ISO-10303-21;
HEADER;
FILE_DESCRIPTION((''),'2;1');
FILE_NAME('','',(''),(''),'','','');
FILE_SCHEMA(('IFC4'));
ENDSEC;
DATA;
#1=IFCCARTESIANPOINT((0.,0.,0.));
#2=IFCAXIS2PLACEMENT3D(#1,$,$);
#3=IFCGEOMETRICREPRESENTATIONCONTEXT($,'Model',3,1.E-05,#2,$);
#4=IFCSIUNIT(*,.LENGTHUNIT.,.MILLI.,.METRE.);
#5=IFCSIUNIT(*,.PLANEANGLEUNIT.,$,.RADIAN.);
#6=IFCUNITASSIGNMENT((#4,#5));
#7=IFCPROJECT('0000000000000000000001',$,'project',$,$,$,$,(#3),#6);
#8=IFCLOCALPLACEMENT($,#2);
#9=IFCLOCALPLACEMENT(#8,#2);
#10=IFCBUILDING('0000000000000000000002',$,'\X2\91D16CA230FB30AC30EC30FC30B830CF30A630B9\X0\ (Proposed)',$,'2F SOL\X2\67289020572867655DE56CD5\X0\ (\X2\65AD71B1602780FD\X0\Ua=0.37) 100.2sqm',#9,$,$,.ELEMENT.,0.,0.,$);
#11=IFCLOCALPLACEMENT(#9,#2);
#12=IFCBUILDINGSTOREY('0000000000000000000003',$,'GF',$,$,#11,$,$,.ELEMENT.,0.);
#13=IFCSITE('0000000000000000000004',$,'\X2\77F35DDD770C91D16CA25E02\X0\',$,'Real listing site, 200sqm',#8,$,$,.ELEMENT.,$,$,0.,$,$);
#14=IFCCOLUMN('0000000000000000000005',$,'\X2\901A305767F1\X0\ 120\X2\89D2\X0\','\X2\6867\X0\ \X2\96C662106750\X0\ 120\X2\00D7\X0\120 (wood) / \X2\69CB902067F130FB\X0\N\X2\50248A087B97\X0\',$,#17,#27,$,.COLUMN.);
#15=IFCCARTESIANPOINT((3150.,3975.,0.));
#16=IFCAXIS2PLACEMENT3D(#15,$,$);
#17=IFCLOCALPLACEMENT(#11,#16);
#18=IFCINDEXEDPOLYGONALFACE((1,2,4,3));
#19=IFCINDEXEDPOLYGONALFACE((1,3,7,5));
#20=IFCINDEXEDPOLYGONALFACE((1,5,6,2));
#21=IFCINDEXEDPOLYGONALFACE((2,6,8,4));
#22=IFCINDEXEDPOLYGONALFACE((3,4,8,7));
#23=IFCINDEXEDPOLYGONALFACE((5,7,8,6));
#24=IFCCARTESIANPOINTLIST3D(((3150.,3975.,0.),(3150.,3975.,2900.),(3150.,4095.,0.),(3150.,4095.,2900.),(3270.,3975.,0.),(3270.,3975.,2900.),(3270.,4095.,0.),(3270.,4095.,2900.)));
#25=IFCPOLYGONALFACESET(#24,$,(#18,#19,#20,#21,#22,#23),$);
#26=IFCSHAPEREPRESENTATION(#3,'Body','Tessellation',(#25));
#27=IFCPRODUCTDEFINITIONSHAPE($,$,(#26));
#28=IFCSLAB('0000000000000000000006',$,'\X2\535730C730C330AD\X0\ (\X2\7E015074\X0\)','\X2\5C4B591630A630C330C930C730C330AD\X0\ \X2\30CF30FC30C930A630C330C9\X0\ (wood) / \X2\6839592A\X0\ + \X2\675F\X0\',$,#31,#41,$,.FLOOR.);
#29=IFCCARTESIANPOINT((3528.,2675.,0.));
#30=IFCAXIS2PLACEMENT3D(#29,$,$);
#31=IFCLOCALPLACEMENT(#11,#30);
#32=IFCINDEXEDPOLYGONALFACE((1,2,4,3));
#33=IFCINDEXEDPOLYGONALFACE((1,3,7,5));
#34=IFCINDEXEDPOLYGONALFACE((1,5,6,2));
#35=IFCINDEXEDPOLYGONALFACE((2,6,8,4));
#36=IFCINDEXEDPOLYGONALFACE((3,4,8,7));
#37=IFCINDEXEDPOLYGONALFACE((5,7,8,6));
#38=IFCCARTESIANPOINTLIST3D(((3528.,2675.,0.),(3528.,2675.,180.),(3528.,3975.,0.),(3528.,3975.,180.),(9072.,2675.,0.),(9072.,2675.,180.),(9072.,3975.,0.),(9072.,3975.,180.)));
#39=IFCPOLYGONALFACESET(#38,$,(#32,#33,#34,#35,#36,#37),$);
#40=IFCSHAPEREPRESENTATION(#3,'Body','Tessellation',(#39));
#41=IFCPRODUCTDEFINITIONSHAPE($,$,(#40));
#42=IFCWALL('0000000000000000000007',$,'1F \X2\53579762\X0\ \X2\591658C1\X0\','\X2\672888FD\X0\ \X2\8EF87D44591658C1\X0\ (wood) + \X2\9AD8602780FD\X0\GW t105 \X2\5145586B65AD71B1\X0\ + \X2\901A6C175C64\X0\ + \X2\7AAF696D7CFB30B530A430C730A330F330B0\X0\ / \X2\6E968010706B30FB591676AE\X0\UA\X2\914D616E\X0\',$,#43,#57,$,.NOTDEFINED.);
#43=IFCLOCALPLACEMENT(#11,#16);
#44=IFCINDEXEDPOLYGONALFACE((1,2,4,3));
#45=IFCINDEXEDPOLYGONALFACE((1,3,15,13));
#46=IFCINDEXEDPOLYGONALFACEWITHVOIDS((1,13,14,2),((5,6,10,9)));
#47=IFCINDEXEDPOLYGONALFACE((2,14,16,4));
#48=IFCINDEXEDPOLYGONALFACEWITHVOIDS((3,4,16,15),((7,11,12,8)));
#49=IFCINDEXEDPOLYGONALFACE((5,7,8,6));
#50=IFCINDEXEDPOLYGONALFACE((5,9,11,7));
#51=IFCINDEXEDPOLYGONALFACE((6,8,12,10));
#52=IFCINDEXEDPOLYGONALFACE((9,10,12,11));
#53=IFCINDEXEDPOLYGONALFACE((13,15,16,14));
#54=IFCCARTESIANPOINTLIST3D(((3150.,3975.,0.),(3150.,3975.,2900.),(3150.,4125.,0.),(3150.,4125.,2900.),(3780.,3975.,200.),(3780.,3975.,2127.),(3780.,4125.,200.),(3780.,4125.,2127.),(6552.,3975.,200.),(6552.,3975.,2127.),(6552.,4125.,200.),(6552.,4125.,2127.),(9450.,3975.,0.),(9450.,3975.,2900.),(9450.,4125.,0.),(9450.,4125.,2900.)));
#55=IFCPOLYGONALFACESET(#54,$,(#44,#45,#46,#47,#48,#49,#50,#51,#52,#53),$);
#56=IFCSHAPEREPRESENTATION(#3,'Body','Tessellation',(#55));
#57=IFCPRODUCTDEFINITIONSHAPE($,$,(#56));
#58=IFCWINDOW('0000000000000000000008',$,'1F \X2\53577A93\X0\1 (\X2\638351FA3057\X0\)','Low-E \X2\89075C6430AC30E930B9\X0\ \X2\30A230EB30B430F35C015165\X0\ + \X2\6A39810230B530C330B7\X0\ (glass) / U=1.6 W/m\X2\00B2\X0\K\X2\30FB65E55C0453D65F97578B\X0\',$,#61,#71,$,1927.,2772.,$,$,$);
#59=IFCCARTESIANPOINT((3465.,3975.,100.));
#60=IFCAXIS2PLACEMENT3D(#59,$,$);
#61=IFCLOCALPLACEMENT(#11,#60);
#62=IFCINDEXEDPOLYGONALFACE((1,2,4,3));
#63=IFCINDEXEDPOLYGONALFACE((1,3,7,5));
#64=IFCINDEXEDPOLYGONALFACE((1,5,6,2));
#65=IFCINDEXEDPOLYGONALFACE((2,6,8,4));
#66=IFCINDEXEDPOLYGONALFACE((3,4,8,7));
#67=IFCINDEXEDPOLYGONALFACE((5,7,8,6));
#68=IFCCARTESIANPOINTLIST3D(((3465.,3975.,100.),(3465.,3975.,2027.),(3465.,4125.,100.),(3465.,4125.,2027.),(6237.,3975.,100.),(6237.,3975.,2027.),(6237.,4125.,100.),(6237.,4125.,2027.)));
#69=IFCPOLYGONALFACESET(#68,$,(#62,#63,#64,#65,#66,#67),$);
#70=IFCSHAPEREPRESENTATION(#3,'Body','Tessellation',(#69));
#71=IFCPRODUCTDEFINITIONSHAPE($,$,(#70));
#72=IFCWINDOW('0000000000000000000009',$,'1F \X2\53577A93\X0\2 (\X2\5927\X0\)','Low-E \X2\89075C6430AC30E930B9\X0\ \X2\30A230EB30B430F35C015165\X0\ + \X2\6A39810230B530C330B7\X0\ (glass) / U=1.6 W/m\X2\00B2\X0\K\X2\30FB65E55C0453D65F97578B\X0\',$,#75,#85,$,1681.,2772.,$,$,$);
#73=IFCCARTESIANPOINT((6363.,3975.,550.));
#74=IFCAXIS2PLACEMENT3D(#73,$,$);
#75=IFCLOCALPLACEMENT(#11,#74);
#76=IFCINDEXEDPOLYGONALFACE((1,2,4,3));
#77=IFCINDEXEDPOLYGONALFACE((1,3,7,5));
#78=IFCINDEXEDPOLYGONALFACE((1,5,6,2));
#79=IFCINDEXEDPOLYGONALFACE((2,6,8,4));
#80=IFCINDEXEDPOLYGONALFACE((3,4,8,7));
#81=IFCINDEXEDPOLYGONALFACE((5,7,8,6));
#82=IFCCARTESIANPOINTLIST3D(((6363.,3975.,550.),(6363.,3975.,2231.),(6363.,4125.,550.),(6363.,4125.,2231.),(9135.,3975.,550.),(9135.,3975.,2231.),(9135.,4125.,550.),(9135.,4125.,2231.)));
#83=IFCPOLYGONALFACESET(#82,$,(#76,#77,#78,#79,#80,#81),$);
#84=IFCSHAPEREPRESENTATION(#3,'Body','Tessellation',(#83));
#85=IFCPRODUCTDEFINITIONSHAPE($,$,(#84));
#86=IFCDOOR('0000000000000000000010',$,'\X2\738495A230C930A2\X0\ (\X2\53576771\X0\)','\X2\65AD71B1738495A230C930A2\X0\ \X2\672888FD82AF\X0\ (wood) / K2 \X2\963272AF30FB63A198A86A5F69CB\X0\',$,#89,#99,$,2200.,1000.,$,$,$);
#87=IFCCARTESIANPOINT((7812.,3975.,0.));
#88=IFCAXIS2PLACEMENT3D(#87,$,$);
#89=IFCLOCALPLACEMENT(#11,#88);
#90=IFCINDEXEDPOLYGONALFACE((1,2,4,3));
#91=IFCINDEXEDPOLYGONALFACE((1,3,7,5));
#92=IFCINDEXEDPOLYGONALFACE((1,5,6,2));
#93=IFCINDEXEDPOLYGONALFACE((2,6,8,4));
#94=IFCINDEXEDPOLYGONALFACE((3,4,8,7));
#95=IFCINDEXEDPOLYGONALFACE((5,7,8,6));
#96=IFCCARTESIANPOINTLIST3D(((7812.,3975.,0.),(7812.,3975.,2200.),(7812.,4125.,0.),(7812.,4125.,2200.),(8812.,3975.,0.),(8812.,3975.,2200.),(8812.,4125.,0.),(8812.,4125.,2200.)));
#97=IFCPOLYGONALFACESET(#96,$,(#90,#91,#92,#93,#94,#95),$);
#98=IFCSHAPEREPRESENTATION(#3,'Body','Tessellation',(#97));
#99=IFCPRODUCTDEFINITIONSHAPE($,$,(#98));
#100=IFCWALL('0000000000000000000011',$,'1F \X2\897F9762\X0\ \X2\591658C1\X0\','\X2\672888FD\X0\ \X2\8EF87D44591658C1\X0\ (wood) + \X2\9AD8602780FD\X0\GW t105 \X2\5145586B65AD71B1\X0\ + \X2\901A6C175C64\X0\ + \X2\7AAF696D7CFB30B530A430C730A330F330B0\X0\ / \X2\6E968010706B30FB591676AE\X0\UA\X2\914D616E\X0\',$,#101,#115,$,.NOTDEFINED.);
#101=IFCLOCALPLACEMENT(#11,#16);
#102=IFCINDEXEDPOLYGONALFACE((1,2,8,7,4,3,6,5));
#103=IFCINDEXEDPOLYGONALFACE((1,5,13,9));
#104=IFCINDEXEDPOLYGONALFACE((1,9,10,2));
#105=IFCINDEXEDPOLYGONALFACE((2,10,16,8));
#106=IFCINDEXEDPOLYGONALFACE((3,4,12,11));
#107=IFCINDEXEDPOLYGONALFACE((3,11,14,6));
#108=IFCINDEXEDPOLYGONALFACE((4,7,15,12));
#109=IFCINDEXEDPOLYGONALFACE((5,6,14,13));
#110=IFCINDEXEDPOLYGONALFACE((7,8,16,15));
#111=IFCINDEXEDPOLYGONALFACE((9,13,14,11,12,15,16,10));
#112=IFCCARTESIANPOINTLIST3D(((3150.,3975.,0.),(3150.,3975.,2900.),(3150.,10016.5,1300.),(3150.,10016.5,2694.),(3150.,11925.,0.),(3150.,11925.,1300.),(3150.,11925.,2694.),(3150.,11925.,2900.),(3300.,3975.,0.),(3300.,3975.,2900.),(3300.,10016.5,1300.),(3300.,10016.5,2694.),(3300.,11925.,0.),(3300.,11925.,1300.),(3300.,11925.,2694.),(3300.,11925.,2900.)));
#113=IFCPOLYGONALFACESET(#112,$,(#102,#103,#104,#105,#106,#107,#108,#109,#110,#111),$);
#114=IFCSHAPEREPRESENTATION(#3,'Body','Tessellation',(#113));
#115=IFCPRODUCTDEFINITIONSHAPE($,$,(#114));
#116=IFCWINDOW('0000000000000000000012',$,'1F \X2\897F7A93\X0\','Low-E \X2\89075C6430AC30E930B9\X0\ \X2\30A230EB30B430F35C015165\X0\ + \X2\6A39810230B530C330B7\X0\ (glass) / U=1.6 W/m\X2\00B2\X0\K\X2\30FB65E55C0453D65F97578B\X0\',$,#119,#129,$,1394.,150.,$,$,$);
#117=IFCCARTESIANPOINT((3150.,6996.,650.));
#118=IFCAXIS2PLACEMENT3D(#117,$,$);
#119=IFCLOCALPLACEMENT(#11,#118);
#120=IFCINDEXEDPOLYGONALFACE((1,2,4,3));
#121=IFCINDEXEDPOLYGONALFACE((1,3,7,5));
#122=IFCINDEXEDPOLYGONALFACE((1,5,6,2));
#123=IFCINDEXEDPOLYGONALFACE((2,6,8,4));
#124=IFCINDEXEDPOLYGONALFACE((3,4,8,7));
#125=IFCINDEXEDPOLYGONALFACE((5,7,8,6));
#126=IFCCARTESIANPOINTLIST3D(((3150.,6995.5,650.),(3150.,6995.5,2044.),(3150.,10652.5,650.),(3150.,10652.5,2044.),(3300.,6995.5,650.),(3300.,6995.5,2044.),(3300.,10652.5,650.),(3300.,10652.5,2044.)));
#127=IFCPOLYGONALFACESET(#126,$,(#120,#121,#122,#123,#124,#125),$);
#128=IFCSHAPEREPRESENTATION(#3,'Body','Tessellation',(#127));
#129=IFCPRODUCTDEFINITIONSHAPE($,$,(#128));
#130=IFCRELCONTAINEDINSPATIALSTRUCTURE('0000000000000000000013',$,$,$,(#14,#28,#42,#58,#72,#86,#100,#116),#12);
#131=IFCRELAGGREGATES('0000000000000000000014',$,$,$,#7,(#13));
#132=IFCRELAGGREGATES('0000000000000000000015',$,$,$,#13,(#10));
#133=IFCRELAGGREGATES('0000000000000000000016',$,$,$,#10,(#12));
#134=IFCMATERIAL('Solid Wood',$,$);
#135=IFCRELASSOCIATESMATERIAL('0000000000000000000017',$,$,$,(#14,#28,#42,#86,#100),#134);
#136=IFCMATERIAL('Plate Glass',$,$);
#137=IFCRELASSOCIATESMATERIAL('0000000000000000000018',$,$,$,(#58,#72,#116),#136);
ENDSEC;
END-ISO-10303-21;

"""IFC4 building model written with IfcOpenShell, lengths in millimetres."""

from ifc_helpers import new_model, si_unit, frame, frame_2d, origin, place, context, project, spatial, rectangle, extrude, material, element, fill, save


model = new_model("IFC4")

# Units and contexts
model_context = context("Model", 3, precision=1e-05, world=origin())
ifc_project = project(units=[si_unit("LENGTHUNIT", "METRE", prefix="MILLI"), si_unit("PLANEANGLEUNIT", "RADIAN")], contexts=[model_context])

# Site, building, storey
site_placement = place(None, origin())
site = spatial("IfcSite", under=ifc_project, at=site_placement, Name="石川県金沢市", ObjectType="Real listing site, 200sqm", CompositionType="ELEMENT", RefElevation=0.0)
building_placement = place(site_placement, origin())
building = spatial("IfcBuilding", under=site, at=building_placement, Name="金沢・ガレージハウス (Proposed)", ObjectType="2F SOL木造在来工法 (断熱性能Ua=0.37) 100.2sqm", CompositionType="ELEMENT", ElevationOfRefHeight=0.0, ElevationOfTerrain=0.0)
storey_placement = place(building_placement, origin())
storey = spatial("IfcBuildingStorey", under=building, at=storey_placement, Name="GF", CompositionType="ELEMENT", Elevation=0.0)

# Column
ifc_material_1 = material(Name="Solid Wood")
column_placement = place(storey_placement, frame((3150.0, 3975.0, 0.0)))
element("IfcColumn", 1, at=column_placement, inside=storey, material=ifc_material_1, Name="通し柱 120角", Description="桧 集成材 120×120 (wood) / 構造柱・N値計算", PredefinedType="COLUMN", context=model_context, shape_type="SweptSolid", body=[
    extrude(rectangle(XDim=120.0, YDim=120.0, at=frame_2d((60.0, 60.0))), frame((3150.0, 3975.0, 0.0)), (0.0, 0.0, 1.0), 2900.0),
])

# Slab
slab_1_placement = place(storey_placement, frame((3528.0, 2675.0, 0.0)))
element("IfcSlab", 2, at=slab_1_placement, inside=storey, material=ifc_material_1, Name="南デッキ (縁側)", Description="屋外ウッドデッキ ハードウッド (wood) / 根太 + 束", PredefinedType="FLOOR", context=model_context, shape_type="SweptSolid", body=[
    extrude(rectangle(XDim=5544.0, YDim=1300.0, at=frame_2d((2772.0, 650.0))), frame((3528.0, 2675.0, 0.0)), (0.0, 0.0, 1.0), 180.0),
])

# Wall, openings, windows, door
wall_1_placement = place(storey_placement, frame((3150.0, 3975.0, 0.0)))
wall_1 = element("IfcWall", 3, at=wall_1_placement, inside=storey, material=ifc_material_1, Name="1F 南面 外壁", Description="木製 軸組外壁 (wood) + 高性能GW t105 充填断熱 + 通気層 + 窯業系サイディング / 準耐火・外皮UA配慮", PredefinedType="NOTDEFINED", context=model_context, shape_type="SweptSolid", body=[
    extrude(rectangle(XDim=6300.0, YDim=150.0, at=frame_2d((3150.0, 75.0))), frame((3150.0, 3975.0, 0.0)), (0.0, 0.0, 1.0), 2900.0),
])
opening_1_placement = place(storey_placement, frame((3465.0, 3975.0, 100.0)))
opening_1 = element("IfcOpeningElement", 4, at=opening_1_placement, cuts=wall_1, PredefinedType="NOTDEFINED", context=model_context, shape_type="SweptSolid", body=[
    extrude(rectangle(XDim=2772.0, YDim=150.0, at=frame_2d((1386.0, 75.0))), frame((3465.0, 3975.0, 100.0)), (0.0, 0.0, 1.0), 1927.0),
])
opening_2_placement = place(storey_placement, frame((6363.0, 3975.0, 550.0)))
opening_2 = element("IfcOpeningElement", 5, at=opening_2_placement, cuts=wall_1, PredefinedType="NOTDEFINED", context=model_context, shape_type="SweptSolid", body=[
    extrude(rectangle(XDim=2772.0, YDim=150.0, at=frame_2d((1386.0, 75.0))), frame((6363.0, 3975.0, 550.0)), (0.0, 0.0, 1.0), 1681.0),
])
opening_3_placement = place(storey_placement, frame((7812.0, 3975.0, 0.0)))
opening_3 = element("IfcOpeningElement", 6, at=opening_3_placement, cuts=wall_1, PredefinedType="NOTDEFINED", context=model_context, shape_type="SweptSolid", body=[
    extrude(rectangle(XDim=1000.0, YDim=150.0, at=frame_2d((500.0, 75.0))), frame((7812.0, 3975.0, 0.0)), (0.0, 0.0, 1.0), 2200.0),
])
ifc_material_2 = material(Name="Plate Glass")
window_1_placement = place(storey_placement, frame((3465.0, 3975.0, 100.0)))
window_1 = element("IfcWindow", 7, at=window_1_placement, inside=storey, material=ifc_material_2, Name="1F 南窓1 (掃出し)", Description="Low-E 複層ガラス アルゴン封入 + 樹脂サッシ (glass) / U=1.6 W/m²K・日射取得型", OverallHeight=1927.0, OverallWidth=2772.0, context=model_context, shape_type="SweptSolid", body=[
    extrude(rectangle(XDim=2772.0, YDim=150.0, at=frame_2d((1386.0, 75.0))), frame((3465.0, 3975.0, 100.0)), (0.0, 0.0, 1.0), 1927.0),
])
fill(opening_1, window_1)
window_2_placement = place(storey_placement, frame((6363.0, 3975.0, 550.0)))
window_2 = element("IfcWindow", 8, at=window_2_placement, inside=storey, material=ifc_material_2, Name="1F 南窓2 (大)", Description="Low-E 複層ガラス アルゴン封入 + 樹脂サッシ (glass) / U=1.6 W/m²K・日射取得型", OverallHeight=1681.0, OverallWidth=2772.0, context=model_context, shape_type="SweptSolid", body=[
    extrude(rectangle(XDim=2772.0, YDim=150.0, at=frame_2d((1386.0, 75.0))), frame((6363.0, 3975.0, 550.0)), (0.0, 0.0, 1.0), 1681.0),
])
fill(opening_2, window_2)
door_placement = place(storey_placement, frame((7812.0, 3975.0, 0.0)))
door = element("IfcDoor", 9, at=door_placement, inside=storey, material=ifc_material_1, Name="玄関ドア (南東)", Description="断熱玄関ドア 木製芯 (wood) / K2 防犯・採風機構", OverallHeight=2200.0, OverallWidth=1000.0, context=model_context, shape_type="SweptSolid", body=[
    extrude(rectangle(XDim=1000.0, YDim=150.0, at=frame_2d((500.0, 75.0))), frame((7812.0, 3975.0, 0.0)), (0.0, 0.0, 1.0), 2200.0),
])
fill(opening_3, door)

# Wall, opening, window
wall_2_placement = place(storey_placement, frame((3150.0, 3975.0, 0.0)))
wall_2 = element("IfcWall", 10, at=wall_2_placement, inside=storey, material=ifc_material_1, Name="1F 西面 外壁", Description="木製 軸組外壁 (wood) + 高性能GW t105 充填断熱 + 通気層 + 窯業系サイディング / 準耐火・外皮UA配慮", PredefinedType="NOTDEFINED", context=model_context, shape_type="SweptSolid", body=[
    extrude(rectangle(XDim=150.0, YDim=7950.0, at=frame_2d((75.0, 3975.0))), frame((3150.0, 3975.0, 0.0)), (0.0, 0.0, 1.0), 2900.0),
])
opening_4_placement = place(storey_placement, frame((3150.0, 6996.0, 650.0)))
opening_4 = element("IfcOpeningElement", 11, at=opening_4_placement, cuts=wall_2, PredefinedType="NOTDEFINED", context=model_context, shape_type="SweptSolid", body=[
    extrude(rectangle(XDim=150.0, YDim=3657.0, at=frame_2d((75.0, 1828.0))), frame((3150.0, 6996.0, 650.0)), (0.0, 0.0, 1.0), 1394.0),
])
window_3_placement = place(storey_placement, frame((3150.0, 6996.0, 650.0)))
window_3 = element("IfcWindow", 12, at=window_3_placement, inside=storey, material=ifc_material_2, Name="1F 西窓", Description="Low-E 複層ガラス アルゴン封入 + 樹脂サッシ (glass) / U=1.6 W/m²K・日射取得型", OverallHeight=1394.0, OverallWidth=150.0, context=model_context, shape_type="SweptSolid", body=[
    extrude(rectangle(XDim=150.0, YDim=3657.0, at=frame_2d((75.0, 1828.0))), frame((3150.0, 6996.0, 650.0)), (0.0, 0.0, 1.0), 1394.0),
])
fill(opening_4, window_3)

save(model, "model.ifc")
